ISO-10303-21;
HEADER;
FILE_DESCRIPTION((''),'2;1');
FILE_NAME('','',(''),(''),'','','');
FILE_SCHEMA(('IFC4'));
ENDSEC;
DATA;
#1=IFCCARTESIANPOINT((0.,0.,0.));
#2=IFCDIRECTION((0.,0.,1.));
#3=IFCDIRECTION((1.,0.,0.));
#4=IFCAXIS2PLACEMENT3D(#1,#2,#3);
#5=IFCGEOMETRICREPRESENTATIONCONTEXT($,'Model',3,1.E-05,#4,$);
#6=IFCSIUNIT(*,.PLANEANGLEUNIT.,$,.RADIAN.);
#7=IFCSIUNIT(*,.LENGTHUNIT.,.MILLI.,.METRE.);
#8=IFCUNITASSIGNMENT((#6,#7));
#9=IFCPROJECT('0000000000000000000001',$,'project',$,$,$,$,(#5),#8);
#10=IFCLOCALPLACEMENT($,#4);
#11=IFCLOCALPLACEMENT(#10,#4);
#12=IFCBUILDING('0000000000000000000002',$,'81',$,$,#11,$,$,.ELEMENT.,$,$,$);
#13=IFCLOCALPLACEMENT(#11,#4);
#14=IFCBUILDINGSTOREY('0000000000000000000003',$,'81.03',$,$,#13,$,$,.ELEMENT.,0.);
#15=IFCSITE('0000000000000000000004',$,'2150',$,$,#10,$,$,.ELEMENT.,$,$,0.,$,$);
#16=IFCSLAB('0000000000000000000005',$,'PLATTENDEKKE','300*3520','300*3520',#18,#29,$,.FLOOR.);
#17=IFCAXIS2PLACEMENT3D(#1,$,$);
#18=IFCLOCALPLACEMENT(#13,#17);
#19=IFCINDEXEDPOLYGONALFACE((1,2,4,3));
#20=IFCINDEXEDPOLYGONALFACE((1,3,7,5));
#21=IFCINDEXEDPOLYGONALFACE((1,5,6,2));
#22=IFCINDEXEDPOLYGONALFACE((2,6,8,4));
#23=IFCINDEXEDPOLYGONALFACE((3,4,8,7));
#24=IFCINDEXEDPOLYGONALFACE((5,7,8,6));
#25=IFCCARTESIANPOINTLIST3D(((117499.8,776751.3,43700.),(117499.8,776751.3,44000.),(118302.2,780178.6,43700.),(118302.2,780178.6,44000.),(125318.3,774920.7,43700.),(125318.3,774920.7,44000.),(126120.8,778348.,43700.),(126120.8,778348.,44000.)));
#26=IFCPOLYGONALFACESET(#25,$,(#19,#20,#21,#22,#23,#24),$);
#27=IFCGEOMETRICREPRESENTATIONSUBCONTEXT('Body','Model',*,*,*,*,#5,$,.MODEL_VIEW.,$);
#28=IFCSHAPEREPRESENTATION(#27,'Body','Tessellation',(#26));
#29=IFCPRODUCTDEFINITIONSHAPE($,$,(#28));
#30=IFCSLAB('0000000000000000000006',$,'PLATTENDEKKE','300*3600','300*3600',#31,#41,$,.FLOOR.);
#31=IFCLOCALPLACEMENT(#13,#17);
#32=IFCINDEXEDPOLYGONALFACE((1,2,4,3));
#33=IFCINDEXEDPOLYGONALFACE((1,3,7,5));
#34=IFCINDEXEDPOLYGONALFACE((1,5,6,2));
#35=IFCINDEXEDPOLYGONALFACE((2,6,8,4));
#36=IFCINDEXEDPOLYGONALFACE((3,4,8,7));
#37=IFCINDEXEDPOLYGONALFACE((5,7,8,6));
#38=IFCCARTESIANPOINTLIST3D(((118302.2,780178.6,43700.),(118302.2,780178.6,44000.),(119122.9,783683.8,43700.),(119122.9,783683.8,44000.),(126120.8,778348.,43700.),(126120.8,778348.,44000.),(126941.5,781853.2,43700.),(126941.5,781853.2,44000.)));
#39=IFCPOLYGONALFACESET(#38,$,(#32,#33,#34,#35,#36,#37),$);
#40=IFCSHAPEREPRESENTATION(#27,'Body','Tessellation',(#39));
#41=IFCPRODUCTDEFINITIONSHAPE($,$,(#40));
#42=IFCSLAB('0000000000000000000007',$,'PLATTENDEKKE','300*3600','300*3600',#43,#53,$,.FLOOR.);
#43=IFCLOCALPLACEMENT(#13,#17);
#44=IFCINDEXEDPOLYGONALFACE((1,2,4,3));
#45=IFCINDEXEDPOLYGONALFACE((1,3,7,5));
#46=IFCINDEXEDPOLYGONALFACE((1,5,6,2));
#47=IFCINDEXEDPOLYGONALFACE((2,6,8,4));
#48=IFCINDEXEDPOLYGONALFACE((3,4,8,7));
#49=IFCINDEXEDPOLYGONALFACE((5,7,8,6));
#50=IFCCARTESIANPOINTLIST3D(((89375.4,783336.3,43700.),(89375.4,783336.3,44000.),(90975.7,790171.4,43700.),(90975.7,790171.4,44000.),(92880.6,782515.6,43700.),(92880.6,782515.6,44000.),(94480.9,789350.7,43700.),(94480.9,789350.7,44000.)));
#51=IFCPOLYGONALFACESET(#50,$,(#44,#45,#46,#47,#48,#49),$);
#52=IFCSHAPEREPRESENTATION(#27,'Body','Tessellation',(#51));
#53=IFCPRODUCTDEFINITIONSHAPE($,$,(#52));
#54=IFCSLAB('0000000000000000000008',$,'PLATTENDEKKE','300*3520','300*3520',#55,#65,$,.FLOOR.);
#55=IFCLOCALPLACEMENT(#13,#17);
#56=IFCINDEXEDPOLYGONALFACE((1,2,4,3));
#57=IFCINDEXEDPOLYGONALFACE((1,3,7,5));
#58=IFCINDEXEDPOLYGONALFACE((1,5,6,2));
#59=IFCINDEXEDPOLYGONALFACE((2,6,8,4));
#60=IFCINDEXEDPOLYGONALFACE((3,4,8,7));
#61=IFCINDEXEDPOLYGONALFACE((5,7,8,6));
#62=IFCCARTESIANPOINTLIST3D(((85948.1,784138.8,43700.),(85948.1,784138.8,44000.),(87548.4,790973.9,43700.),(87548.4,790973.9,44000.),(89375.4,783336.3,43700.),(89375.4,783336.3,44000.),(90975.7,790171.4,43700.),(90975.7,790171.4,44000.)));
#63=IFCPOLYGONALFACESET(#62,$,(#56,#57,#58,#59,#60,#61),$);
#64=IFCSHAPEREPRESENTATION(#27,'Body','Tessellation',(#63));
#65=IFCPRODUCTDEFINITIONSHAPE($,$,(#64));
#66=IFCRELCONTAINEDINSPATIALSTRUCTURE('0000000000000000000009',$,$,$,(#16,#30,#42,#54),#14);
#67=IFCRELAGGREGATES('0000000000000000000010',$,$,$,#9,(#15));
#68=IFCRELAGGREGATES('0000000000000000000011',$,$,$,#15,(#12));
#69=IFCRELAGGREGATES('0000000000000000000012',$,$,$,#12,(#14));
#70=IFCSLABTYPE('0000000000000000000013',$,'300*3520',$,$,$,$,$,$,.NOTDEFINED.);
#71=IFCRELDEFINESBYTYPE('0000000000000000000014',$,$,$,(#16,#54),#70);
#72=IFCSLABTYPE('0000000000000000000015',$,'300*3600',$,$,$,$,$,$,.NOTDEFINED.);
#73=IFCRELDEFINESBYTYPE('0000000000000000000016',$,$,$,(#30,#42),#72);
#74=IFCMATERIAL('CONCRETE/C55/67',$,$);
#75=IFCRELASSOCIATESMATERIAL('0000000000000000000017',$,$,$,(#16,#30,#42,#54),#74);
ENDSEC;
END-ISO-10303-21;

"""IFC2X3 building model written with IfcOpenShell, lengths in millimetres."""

from ifc_helpers import new_model, si_unit, frame, origin, origin_with_axes, origin_2d_with_axis, place, context, subcontext, project, spatial, rectangle, extrude, source, transform, mapped, material, type_object, element, save


model = new_model("IFC2X3")

# Units and contexts
model_context = context("Model", 3, precision=1e-05, world=origin_with_axes())
body_context = subcontext(model_context, "Body", "Model", "MODEL_VIEW")
ifc_project = project(units=[si_unit("PLANEANGLEUNIT", "RADIAN"), si_unit("LENGTHUNIT", "METRE", prefix="MILLI")], contexts=[model_context])

# Site, building, storey
site_placement = place(None, origin_with_axes())
site = spatial("IfcSite", under=ifc_project, at=site_placement, Name="2150", CompositionType="ELEMENT", RefElevation=0.0)
building_placement = place(site_placement, origin_with_axes())
building = spatial("IfcBuilding", under=site, at=building_placement, Name="81", CompositionType="ELEMENT")
storey_placement = place(building_placement, origin_with_axes())
storey = spatial("IfcBuildingStorey", under=building, at=storey_placement, Name="81.03", CompositionType="ELEMENT", Elevation=0.0)

# Slabs
ifc_material = material(Name="CONCRETE/C55/67")
slab_type_1 = type_object("IfcSlabType", Name="300*3600", PredefinedType="NOTDEFINED")
slab_type_2 = type_object("IfcSlabType", Name="300*3520", PredefinedType="NOTDEFINED")
shared_shape_1 = source(origin(), body_context, "Body", "SweptSolid", [
    extrude(rectangle(XDim=3520.0, YDim=300.0, at=origin_2d_with_axis()), frame((8030.0, 0.0, 0.0), z_axis=(-1.0, 0.0, 0.0), x_axis=(0.0, -1.0, 0.0)), (0.0, 0.0, 1.0), 8030.0),
])
slab_1_placement = place(storey_placement, frame((125719.5, 776634.3, 43850.0), z_axis=(0.0, 0.0, 1.0), x_axis=(-0.973667, 0.227973, 0.0)))
element("IfcSlab", 1, at=slab_1_placement, inside=storey, type_object=slab_type_2, material=ifc_material, Name="PLATTENDEKKE", Description="300*3520", ObjectType="300*3520", PredefinedType="FLOOR", context=body_context, shape_type="MappedRepresentation", body=[
    mapped(shared_shape_1, transform((0.0, 0.0, 0.0))),
])
shared_shape_2 = source(origin(), body_context, "Body", "SweptSolid", [
    extrude(rectangle(XDim=3600.0, YDim=300.0, at=origin_2d_with_axis()), frame((8030.0, 0.0, 0.0), z_axis=(-1.0, 0.0, 0.0), x_axis=(0.0, -1.0, 0.0)), (0.0, 0.0, 1.0), 8030.0),
])
slab_2_placement = place(storey_placement, frame((126531.1, 780100.6, 43850.0), z_axis=(0.0, 0.0, 1.0), x_axis=(-0.973667, 0.227973, 0.0)))
element("IfcSlab", 2, at=slab_2_placement, inside=storey, type_object=slab_type_1, material=ifc_material, Name="PLATTENDEKKE", Description="300*3600", ObjectType="300*3600", PredefinedType="FLOOR", context=body_context, shape_type="MappedRepresentation", body=[
    mapped(shared_shape_2, transform((0.0, 0.0, 0.0))),
])
shared_shape_3 = source(origin(), body_context, "Body", "SweptSolid", [
    extrude(rectangle(XDim=3600.0, YDim=300.0, at=origin_2d_with_axis()), frame((7020.0, 0.0, 0.0), z_axis=(-1.0, 0.0, 0.0), x_axis=(0.0, -1.0, 0.0)), (0.0, 0.0, 1.0), 7020.0),
])
slab_3_placement = place(storey_placement, frame((91128.0, 782925.9, 43850.0), z_axis=(0.0, 0.0, 1.0), x_axis=(0.227973, 0.973667, 0.0)))
element("IfcSlab", 3, at=slab_3_placement, inside=storey, type_object=slab_type_1, material=ifc_material, Name="PLATTENDEKKE", Description="300*3600", ObjectType="300*3600", PredefinedType="FLOOR", context=body_context, shape_type="MappedRepresentation", body=[
    mapped(shared_shape_3, transform((0.0, 0.0, 0.0))),
])
shared_shape_4 = source(origin(), body_context, "Body", "SweptSolid", [
    extrude(rectangle(XDim=3520.0, YDim=300.0, at=origin_2d_with_axis()), frame((7020.0, 0.0, 0.0), z_axis=(-1.0, 0.0, 0.0), x_axis=(0.0, -1.0, 0.0)), (0.0, 0.0, 1.0), 7020.0),
])
slab_4_placement = place(storey_placement, frame((87661.7, 783737.5, 43850.0), z_axis=(0.0, 0.0, 1.0), x_axis=(0.227973, 0.973667, 0.0)))
element("IfcSlab", 4, at=slab_4_placement, inside=storey, type_object=slab_type_2, material=ifc_material, Name="PLATTENDEKKE", Description="300*3520", ObjectType="300*3520", PredefinedType="FLOOR", context=body_context, shape_type="MappedRepresentation", body=[
    mapped(shared_shape_4, transform((0.0, 0.0, 0.0))),
])

save(model, "model.ifc")
